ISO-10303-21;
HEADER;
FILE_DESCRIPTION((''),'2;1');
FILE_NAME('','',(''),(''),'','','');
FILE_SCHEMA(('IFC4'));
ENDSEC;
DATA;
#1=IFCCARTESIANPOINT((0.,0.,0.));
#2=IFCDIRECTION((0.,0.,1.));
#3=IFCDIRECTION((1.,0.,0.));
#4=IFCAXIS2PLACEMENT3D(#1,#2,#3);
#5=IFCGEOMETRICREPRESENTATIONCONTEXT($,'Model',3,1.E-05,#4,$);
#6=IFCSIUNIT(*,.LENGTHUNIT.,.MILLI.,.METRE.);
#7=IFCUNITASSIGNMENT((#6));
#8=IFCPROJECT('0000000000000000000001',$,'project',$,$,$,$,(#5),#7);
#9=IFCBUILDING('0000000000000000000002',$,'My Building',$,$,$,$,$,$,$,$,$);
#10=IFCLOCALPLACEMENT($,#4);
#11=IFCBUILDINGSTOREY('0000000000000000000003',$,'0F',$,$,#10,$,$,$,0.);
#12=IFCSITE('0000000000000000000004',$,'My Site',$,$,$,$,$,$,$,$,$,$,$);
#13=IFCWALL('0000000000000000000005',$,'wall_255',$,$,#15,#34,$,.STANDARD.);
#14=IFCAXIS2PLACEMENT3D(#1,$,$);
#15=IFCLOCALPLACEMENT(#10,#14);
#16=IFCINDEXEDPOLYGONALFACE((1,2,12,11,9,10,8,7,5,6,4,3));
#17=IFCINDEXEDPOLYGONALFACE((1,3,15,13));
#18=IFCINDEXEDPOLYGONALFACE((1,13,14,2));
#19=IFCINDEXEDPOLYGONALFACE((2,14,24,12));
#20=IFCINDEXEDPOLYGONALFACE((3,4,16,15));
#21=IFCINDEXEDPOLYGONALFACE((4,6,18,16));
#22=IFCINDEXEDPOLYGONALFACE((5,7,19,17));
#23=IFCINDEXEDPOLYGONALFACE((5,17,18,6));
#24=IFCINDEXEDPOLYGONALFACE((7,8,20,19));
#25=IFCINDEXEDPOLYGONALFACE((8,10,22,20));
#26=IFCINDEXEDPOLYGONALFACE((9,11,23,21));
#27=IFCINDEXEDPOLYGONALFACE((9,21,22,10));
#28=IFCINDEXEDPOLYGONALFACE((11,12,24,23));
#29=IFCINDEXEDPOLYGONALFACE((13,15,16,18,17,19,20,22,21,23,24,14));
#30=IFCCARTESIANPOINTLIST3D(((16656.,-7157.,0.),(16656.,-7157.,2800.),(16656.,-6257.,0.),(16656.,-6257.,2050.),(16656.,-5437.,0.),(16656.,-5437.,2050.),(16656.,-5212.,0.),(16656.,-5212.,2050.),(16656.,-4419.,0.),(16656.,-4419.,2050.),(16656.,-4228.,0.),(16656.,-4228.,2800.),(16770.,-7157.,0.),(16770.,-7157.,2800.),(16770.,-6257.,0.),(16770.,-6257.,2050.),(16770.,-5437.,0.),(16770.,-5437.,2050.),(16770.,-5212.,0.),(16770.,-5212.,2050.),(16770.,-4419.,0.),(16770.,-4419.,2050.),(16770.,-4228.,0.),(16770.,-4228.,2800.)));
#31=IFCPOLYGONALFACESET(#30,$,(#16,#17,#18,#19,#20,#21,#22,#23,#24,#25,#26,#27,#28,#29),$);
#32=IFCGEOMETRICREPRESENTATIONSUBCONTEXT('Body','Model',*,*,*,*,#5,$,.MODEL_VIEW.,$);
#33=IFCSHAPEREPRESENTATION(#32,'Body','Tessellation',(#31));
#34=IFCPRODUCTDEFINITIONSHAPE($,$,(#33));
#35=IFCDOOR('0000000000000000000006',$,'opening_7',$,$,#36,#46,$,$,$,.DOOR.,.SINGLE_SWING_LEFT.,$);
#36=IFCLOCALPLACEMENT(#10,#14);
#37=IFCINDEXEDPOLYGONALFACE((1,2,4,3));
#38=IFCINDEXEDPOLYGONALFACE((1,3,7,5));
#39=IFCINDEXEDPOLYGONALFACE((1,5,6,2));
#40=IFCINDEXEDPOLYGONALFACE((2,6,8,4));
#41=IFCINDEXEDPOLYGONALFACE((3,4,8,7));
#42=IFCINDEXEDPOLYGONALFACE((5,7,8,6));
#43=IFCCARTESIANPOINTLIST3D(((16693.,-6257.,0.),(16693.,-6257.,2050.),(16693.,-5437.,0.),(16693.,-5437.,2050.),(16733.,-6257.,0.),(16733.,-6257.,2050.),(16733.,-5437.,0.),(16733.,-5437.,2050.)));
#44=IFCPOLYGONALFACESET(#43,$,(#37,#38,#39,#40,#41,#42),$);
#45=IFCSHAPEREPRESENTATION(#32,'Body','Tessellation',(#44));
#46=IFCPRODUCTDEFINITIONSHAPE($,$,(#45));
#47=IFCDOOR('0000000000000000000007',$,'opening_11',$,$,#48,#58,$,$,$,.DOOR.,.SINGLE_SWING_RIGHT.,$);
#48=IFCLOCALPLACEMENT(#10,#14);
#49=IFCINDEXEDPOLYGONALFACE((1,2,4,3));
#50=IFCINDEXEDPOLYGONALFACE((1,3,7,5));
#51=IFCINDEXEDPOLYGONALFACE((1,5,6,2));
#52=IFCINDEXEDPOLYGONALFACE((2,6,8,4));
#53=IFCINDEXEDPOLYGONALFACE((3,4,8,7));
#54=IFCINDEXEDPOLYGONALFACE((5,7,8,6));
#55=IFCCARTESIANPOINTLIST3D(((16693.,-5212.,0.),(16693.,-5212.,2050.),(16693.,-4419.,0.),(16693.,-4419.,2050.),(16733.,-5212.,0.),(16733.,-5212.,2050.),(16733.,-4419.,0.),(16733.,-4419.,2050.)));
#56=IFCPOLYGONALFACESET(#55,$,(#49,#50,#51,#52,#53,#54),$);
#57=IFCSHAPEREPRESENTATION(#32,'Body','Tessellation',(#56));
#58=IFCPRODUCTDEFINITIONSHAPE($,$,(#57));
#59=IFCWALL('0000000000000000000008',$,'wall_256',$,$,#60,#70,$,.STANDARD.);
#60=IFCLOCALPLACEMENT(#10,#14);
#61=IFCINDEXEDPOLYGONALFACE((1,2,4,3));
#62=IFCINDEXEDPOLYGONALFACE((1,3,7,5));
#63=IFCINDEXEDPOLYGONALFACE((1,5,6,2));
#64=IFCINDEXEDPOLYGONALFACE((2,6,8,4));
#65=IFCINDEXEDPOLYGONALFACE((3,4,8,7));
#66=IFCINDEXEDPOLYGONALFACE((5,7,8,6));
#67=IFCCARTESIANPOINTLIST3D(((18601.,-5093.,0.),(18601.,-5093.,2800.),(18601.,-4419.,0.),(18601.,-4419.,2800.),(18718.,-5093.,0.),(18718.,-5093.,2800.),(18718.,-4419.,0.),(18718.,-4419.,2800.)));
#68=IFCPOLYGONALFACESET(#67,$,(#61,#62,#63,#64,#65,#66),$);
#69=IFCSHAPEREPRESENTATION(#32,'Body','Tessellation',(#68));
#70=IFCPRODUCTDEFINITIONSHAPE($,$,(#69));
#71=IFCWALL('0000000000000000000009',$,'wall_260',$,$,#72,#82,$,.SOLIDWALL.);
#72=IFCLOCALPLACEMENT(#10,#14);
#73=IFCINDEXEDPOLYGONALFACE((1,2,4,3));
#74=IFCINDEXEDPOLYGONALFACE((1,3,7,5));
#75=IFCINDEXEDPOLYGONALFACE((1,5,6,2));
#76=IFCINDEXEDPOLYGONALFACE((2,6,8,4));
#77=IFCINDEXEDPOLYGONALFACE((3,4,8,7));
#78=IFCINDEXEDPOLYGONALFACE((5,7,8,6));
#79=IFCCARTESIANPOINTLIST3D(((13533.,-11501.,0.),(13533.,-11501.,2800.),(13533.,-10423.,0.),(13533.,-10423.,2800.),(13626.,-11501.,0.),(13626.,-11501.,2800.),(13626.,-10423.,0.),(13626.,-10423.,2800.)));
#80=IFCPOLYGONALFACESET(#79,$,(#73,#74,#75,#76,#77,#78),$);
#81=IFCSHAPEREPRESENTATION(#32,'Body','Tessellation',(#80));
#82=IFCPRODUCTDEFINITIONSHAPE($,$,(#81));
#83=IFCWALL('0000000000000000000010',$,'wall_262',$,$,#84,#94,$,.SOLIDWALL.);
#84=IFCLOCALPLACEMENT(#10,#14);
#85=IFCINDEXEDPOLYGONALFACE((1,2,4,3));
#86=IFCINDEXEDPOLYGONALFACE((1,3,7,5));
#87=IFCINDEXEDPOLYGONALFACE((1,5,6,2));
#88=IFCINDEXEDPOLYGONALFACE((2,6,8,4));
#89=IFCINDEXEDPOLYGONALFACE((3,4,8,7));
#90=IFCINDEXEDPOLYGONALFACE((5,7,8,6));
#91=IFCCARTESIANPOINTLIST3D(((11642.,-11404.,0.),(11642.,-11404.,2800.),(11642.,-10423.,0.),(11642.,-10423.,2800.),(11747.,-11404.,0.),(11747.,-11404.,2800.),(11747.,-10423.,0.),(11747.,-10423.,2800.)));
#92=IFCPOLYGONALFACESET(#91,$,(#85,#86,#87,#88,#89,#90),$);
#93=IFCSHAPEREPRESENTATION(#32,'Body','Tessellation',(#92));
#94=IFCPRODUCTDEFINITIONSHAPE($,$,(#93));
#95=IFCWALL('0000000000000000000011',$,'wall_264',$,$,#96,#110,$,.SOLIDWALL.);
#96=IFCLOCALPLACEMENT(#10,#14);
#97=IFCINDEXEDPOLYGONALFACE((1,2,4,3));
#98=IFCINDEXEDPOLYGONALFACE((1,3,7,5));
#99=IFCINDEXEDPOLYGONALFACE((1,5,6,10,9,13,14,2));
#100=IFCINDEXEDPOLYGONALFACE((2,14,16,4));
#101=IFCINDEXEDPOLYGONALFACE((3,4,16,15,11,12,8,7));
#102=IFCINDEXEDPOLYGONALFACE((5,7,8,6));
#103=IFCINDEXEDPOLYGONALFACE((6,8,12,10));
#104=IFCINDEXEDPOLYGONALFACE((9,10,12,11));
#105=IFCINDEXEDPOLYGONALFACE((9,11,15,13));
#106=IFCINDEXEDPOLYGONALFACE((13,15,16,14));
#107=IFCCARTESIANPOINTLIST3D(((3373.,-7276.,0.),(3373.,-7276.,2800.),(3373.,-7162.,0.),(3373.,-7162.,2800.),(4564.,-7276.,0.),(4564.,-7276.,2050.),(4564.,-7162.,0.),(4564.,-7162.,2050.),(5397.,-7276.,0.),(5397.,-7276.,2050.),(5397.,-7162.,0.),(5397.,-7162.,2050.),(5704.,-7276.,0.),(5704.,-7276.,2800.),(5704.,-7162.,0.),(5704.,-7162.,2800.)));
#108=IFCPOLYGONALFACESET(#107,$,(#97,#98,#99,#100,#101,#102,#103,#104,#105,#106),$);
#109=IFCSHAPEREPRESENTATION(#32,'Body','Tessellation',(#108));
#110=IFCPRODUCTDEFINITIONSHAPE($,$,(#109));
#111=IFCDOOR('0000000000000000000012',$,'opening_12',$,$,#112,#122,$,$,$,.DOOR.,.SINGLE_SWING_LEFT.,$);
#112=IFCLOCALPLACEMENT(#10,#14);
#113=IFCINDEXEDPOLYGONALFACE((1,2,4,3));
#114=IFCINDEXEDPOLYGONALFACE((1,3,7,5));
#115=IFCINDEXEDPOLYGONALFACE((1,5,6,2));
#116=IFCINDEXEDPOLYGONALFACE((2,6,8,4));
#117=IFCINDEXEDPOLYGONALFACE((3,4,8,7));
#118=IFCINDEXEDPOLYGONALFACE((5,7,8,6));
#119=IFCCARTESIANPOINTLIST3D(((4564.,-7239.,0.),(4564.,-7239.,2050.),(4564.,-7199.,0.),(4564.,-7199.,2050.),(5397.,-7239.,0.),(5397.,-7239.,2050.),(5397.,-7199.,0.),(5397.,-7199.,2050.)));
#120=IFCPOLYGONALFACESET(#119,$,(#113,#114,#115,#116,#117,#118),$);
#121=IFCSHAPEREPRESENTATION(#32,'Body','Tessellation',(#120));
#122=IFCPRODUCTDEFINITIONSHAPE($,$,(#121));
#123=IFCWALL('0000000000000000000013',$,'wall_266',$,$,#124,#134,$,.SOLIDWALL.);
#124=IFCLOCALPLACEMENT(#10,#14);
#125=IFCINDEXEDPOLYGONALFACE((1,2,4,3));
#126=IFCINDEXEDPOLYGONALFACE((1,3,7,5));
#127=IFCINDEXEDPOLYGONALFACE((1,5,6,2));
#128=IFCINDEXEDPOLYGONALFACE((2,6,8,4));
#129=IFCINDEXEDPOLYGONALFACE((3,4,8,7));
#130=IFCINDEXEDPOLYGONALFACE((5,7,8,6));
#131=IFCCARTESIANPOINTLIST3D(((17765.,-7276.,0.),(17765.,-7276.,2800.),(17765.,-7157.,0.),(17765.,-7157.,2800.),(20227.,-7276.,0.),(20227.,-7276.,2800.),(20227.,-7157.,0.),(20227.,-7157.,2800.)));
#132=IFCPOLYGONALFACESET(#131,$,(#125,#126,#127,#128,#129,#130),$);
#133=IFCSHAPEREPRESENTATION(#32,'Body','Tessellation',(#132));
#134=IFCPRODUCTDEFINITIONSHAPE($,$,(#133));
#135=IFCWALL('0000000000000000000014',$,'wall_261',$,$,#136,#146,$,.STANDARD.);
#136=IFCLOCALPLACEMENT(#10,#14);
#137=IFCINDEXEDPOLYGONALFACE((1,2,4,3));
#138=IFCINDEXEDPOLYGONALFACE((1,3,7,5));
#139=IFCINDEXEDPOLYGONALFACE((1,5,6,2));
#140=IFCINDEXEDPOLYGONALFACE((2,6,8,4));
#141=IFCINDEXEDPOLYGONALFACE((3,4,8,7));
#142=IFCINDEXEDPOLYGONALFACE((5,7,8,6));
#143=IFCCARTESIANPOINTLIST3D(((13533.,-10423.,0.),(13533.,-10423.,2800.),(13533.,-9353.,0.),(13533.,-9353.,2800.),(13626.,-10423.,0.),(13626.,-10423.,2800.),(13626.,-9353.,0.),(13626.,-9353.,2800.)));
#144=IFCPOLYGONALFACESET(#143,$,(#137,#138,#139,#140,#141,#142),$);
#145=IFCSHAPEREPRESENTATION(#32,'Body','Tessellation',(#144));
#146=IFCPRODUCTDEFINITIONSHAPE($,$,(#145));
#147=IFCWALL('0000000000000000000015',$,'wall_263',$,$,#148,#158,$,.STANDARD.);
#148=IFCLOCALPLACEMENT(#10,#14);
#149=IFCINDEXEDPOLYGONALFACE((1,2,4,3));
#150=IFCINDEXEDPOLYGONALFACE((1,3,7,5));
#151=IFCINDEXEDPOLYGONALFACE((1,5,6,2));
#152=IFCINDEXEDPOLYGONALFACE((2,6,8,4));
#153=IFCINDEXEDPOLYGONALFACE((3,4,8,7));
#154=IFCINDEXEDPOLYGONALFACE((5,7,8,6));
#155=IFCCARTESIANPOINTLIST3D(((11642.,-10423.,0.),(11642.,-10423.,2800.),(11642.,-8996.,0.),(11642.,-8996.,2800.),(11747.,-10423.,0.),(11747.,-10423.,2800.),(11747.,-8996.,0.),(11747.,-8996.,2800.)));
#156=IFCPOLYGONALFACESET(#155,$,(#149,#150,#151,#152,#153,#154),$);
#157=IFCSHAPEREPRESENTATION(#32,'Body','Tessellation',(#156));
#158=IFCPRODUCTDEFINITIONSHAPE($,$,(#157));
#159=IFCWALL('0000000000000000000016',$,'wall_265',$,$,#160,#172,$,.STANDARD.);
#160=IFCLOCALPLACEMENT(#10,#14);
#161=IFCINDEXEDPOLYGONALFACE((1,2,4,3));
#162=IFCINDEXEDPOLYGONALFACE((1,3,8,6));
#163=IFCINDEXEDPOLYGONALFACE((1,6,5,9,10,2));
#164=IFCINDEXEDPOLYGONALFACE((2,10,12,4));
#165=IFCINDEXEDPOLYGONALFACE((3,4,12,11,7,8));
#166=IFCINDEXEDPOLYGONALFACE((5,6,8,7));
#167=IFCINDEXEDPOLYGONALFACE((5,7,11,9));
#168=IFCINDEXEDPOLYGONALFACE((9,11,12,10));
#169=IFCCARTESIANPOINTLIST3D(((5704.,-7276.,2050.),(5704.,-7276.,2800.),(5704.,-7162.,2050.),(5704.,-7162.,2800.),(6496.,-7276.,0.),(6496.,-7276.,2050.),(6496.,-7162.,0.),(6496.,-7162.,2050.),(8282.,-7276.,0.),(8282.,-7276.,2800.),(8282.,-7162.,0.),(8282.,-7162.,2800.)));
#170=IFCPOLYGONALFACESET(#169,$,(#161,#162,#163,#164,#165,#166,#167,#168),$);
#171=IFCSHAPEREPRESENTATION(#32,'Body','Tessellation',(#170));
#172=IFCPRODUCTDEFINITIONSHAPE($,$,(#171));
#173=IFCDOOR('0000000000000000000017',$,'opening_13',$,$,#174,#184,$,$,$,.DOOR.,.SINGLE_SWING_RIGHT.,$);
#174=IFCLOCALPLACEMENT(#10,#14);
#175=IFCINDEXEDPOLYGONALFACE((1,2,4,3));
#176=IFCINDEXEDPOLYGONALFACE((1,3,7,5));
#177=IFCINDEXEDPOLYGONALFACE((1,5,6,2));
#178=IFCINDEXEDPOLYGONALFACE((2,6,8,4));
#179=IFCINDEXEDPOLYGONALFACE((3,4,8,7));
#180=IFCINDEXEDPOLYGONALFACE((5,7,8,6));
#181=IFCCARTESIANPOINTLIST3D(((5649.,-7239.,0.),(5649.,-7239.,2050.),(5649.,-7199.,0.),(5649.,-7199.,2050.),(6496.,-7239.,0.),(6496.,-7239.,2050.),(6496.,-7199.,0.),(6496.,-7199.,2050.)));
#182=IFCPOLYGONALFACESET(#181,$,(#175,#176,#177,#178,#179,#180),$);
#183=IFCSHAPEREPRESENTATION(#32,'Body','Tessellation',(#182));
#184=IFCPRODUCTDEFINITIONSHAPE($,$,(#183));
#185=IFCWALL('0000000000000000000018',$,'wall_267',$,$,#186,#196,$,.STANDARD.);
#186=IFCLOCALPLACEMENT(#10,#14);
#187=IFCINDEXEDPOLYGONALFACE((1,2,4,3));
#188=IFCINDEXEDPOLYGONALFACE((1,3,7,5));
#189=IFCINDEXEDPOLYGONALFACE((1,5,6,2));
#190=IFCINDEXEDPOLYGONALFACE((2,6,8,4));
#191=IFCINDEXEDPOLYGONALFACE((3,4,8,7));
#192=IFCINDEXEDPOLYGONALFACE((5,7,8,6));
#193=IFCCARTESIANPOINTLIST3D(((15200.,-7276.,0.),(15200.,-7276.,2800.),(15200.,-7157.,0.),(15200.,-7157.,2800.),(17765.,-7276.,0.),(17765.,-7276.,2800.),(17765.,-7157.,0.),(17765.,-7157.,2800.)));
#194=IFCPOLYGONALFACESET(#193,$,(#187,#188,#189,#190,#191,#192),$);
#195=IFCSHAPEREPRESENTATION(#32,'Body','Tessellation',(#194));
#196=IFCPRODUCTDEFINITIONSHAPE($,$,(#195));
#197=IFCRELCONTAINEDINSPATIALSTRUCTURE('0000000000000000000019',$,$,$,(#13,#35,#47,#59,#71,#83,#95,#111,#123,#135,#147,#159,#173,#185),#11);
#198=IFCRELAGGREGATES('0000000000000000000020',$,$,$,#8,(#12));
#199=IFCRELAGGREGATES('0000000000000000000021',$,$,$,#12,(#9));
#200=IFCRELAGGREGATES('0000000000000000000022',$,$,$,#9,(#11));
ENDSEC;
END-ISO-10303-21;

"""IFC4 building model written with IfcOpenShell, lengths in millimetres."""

from ifc_helpers import new_model, si_unit, origin_with_axes, place, context, subcontext, project, spatial, indexed_curve, outline, extrude, element, fill, save


model = new_model("IFC4")

# Units and contexts
model_context = context("Model", 3, precision=1e-05, world=origin_with_axes())
body_context = subcontext(model_context, "Body", "Model", "MODEL_VIEW")
ifc_project = project(units=[si_unit("LENGTHUNIT", "METRE", prefix="MILLI")], contexts=[model_context])

# Site, building, storey
site = spatial("IfcSite", under=ifc_project, Name="My Site")
building = spatial("IfcBuilding", under=site, Name="My Building")
storey_placement = place(None, origin_with_axes())
storey = spatial("IfcBuildingStorey", under=building, at=storey_placement, Name="0F", Elevation=0.0)

# Wall, openings, doors
wall_1_placement = place(storey_placement, origin_with_axes())
wall_1 = element("IfcWall", 1, at=wall_1_placement, inside=storey, Name="wall_255", PredefinedType="STANDARD", context=body_context, shape_type="SweptSolid", body=[
    extrude(outline(indexed_curve([(16656.0, -4228.0), (16656.0, -7157.0), (16770.0, -7157.0), (16770.0, -4228.0), (16656.0, -4228.0)])), None, (0.0, 0.0, 1.0), 2800.0),
])
opening_1_placement = place(wall_1_placement, origin_with_axes())
opening_1 = element("IfcOpeningElement", 2, at=opening_1_placement, cuts=wall_1, ObjectType="Opening", context=body_context, shape_type="SweptSolid", body=[
    extrude(outline(indexed_curve([(16590.0, -6257.0), (16836.0, -6257.0), (16836.0, -5437.0), (16590.0, -5437.0), (16590.0, -6257.0)])), None, (0.0, 0.0, 1.0), 2050.0),
])
opening_2_placement = place(wall_1_placement, origin_with_axes())
opening_2 = element("IfcOpeningElement", 3, at=opening_2_placement, cuts=wall_1, ObjectType="Opening", context=body_context, shape_type="SweptSolid", body=[
    extrude(outline(indexed_curve([(16590.0, -5212.0), (16836.0, -5212.0), (16836.0, -4419.0), (16590.0, -4419.0), (16590.0, -5212.0)])), None, (0.0, 0.0, 1.0), 2050.0),
])
door_1_placement = place(opening_1_placement, origin_with_axes())
door_1 = element("IfcDoor", 4, at=door_1_placement, inside=storey, Name="opening_7", OperationType="SINGLE_SWING_LEFT", PredefinedType="DOOR", context=body_context, shape_type="SweptSolid", body=[
    extrude(outline(indexed_curve([(16693.0, -6257.0), (16733.0, -6257.0), (16733.0, -5437.0), (16693.0, -5437.0), (16693.0, -6257.0)])), None, (0.0, 0.0, 1.0), 2050.0),
])
fill(opening_1, door_1)
door_2_placement = place(opening_2_placement, origin_with_axes())
door_2 = element("IfcDoor", 5, at=door_2_placement, inside=storey, Name="opening_11", OperationType="SINGLE_SWING_RIGHT", PredefinedType="DOOR", context=body_context, shape_type="SweptSolid", body=[
    extrude(outline(indexed_curve([(16693.0, -5212.0), (16733.0, -5212.0), (16733.0, -4419.0), (16693.0, -4419.0), (16693.0, -5212.0)])), None, (0.0, 0.0, 1.0), 2050.0),
])
fill(opening_2, door_2)

# Walls
wall_2_placement = place(storey_placement, origin_with_axes())
element("IfcWall", 6, at=wall_2_placement, inside=storey, Name="wall_256", PredefinedType="STANDARD", context=body_context, shape_type="SweptSolid", body=[
    extrude(outline(indexed_curve([(18601.0, -4419.0), (18601.0, -5093.0), (18718.0, -5093.0), (18718.0, -4419.0), (18601.0, -4419.0)])), None, (0.0, 0.0, 1.0), 2800.0),
])
wall_3_placement = place(storey_placement, origin_with_axes())
element("IfcWall", 7, at=wall_3_placement, inside=storey, Name="wall_260", PredefinedType="SOLIDWALL", context=body_context, shape_type="SweptSolid", body=[
    extrude(outline(indexed_curve([(13533.0, -10423.0), (13533.0, -11501.0), (13626.0, -11501.0), (13626.0, -10423.0), (13533.0, -10423.0)])), None, (0.0, 0.0, 1.0), 2800.0),
])
wall_4_placement = place(storey_placement, origin_with_axes())
element("IfcWall", 8, at=wall_4_placement, inside=storey, Name="wall_262", PredefinedType="SOLIDWALL", context=body_context, shape_type="SweptSolid", body=[
    extrude(outline(indexed_curve([(11642.0, -10423.0), (11642.0, -11404.0), (11747.0, -11404.0), (11747.0, -10423.0), (11642.0, -10423.0)])), None, (0.0, 0.0, 1.0), 2800.0),
])

# Wall, opening, door
wall_5_placement = place(storey_placement, origin_with_axes())
wall_5 = element("IfcWall", 9, at=wall_5_placement, inside=storey, Name="wall_264", PredefinedType="SOLIDWALL", context=body_context, shape_type="SweptSolid", body=[
    extrude(outline(indexed_curve([(3373.0, -7276.0), (5704.0, -7276.0), (5704.0, -7162.0), (3373.0, -7162.0), (3373.0, -7276.0)])), None, (0.0, 0.0, 1.0), 2800.0),
])
opening_3_placement = place(wall_5_placement, origin_with_axes())
opening_3 = element("IfcOpeningElement", 10, at=opening_3_placement, cuts=wall_5, ObjectType="Opening", context=body_context, shape_type="SweptSolid", body=[
    extrude(outline(indexed_curve([(5397.0, -7342.0), (5397.0, -7095.0), (4564.0, -7095.0), (4564.0, -7342.0), (5397.0, -7342.0)])), None, (0.0, 0.0, 1.0), 2050.0),
])
door_3_placement = place(opening_3_placement, origin_with_axes())
door_3 = element("IfcDoor", 11, at=door_3_placement, inside=storey, Name="opening_12", OperationType="SINGLE_SWING_LEFT", PredefinedType="DOOR", context=body_context, shape_type="SweptSolid", body=[
    extrude(outline(indexed_curve([(5397.0, -7239.0), (5397.0, -7199.0), (4564.0, -7199.0), (4564.0, -7239.0), (5397.0, -7239.0)])), None, (0.0, 0.0, 1.0), 2050.0),
])
fill(opening_3, door_3)

# Walls
wall_6_placement = place(storey_placement, origin_with_axes())
element("IfcWall", 12, at=wall_6_placement, inside=storey, Name="wall_266", PredefinedType="SOLIDWALL", context=body_context, shape_type="SweptSolid", body=[
    extrude(outline(indexed_curve([(17765.0, -7276.0), (20227.0, -7276.0), (20227.0, -7157.0), (17765.0, -7157.0), (17765.0, -7276.0)])), None, (0.0, 0.0, 1.0), 2800.0),
])
wall_7_placement = place(storey_placement, origin_with_axes())
element("IfcWall", 13, at=wall_7_placement, inside=storey, Name="wall_261", PredefinedType="STANDARD", context=body_context, shape_type="SweptSolid", body=[
    extrude(outline(indexed_curve([(13533.0, -9353.0), (13533.0, -10423.0), (13626.0, -10423.0), (13626.0, -9353.0), (13533.0, -9353.0)])), None, (0.0, 0.0, 1.0), 2800.0),
])
wall_8_placement = place(storey_placement, origin_with_axes())
element("IfcWall", 14, at=wall_8_placement, inside=storey, Name="wall_263", PredefinedType="STANDARD", context=body_context, shape_type="SweptSolid", body=[
    extrude(outline(indexed_curve([(11642.0, -8996.0), (11642.0, -10423.0), (11747.0, -10423.0), (11747.0, -8996.0), (11642.0, -8996.0)])), None, (0.0, 0.0, 1.0), 2800.0),
])

# Wall, opening, door
wall_9_placement = place(storey_placement, origin_with_axes())
wall_9 = element("IfcWall", 15, at=wall_9_placement, inside=storey, Name="wall_265", PredefinedType="STANDARD", context=body_context, shape_type="SweptSolid", body=[
    extrude(outline(indexed_curve([(5704.0, -7276.0), (8282.0, -7276.0), (8282.0, -7162.0), (5704.0, -7162.0), (5704.0, -7276.0)])), None, (0.0, 0.0, 1.0), 2800.0),
])
opening_4_placement = place(wall_9_placement, origin_with_axes())
opening_4 = element("IfcOpeningElement", 16, at=opening_4_placement, cuts=wall_9, ObjectType="Opening", context=body_context, shape_type="SweptSolid", body=[
    extrude(outline(indexed_curve([(6496.0, -7342.0), (6496.0, -7095.0), (5649.0, -7095.0), (5649.0, -7342.0), (6496.0, -7342.0)])), None, (0.0, 0.0, 1.0), 2050.0),
])
door_4_placement = place(opening_4_placement, origin_with_axes())
door_4 = element("IfcDoor", 17, at=door_4_placement, inside=storey, Name="opening_13", OperationType="SINGLE_SWING_RIGHT", PredefinedType="DOOR", context=body_context, shape_type="SweptSolid", body=[
    extrude(outline(indexed_curve([(6496.0, -7239.0), (6496.0, -7199.0), (5649.0, -7199.0), (5649.0, -7239.0), (6496.0, -7239.0)])), None, (0.0, 0.0, 1.0), 2050.0),
])
fill(opening_4, door_4)

# Wall
wall_10_placement = place(storey_placement, origin_with_axes())
element("IfcWall", 18, at=wall_10_placement, inside=storey, Name="wall_267", PredefinedType="STANDARD", context=body_context, shape_type="SweptSolid", body=[
    extrude(outline(indexed_curve([(15200.0, -7276.0), (17765.0, -7276.0), (17765.0, -7157.0), (15200.0, -7157.0), (15200.0, -7276.0)])), None, (0.0, 0.0, 1.0), 2800.0),
])

save(model, "model.ifc")
